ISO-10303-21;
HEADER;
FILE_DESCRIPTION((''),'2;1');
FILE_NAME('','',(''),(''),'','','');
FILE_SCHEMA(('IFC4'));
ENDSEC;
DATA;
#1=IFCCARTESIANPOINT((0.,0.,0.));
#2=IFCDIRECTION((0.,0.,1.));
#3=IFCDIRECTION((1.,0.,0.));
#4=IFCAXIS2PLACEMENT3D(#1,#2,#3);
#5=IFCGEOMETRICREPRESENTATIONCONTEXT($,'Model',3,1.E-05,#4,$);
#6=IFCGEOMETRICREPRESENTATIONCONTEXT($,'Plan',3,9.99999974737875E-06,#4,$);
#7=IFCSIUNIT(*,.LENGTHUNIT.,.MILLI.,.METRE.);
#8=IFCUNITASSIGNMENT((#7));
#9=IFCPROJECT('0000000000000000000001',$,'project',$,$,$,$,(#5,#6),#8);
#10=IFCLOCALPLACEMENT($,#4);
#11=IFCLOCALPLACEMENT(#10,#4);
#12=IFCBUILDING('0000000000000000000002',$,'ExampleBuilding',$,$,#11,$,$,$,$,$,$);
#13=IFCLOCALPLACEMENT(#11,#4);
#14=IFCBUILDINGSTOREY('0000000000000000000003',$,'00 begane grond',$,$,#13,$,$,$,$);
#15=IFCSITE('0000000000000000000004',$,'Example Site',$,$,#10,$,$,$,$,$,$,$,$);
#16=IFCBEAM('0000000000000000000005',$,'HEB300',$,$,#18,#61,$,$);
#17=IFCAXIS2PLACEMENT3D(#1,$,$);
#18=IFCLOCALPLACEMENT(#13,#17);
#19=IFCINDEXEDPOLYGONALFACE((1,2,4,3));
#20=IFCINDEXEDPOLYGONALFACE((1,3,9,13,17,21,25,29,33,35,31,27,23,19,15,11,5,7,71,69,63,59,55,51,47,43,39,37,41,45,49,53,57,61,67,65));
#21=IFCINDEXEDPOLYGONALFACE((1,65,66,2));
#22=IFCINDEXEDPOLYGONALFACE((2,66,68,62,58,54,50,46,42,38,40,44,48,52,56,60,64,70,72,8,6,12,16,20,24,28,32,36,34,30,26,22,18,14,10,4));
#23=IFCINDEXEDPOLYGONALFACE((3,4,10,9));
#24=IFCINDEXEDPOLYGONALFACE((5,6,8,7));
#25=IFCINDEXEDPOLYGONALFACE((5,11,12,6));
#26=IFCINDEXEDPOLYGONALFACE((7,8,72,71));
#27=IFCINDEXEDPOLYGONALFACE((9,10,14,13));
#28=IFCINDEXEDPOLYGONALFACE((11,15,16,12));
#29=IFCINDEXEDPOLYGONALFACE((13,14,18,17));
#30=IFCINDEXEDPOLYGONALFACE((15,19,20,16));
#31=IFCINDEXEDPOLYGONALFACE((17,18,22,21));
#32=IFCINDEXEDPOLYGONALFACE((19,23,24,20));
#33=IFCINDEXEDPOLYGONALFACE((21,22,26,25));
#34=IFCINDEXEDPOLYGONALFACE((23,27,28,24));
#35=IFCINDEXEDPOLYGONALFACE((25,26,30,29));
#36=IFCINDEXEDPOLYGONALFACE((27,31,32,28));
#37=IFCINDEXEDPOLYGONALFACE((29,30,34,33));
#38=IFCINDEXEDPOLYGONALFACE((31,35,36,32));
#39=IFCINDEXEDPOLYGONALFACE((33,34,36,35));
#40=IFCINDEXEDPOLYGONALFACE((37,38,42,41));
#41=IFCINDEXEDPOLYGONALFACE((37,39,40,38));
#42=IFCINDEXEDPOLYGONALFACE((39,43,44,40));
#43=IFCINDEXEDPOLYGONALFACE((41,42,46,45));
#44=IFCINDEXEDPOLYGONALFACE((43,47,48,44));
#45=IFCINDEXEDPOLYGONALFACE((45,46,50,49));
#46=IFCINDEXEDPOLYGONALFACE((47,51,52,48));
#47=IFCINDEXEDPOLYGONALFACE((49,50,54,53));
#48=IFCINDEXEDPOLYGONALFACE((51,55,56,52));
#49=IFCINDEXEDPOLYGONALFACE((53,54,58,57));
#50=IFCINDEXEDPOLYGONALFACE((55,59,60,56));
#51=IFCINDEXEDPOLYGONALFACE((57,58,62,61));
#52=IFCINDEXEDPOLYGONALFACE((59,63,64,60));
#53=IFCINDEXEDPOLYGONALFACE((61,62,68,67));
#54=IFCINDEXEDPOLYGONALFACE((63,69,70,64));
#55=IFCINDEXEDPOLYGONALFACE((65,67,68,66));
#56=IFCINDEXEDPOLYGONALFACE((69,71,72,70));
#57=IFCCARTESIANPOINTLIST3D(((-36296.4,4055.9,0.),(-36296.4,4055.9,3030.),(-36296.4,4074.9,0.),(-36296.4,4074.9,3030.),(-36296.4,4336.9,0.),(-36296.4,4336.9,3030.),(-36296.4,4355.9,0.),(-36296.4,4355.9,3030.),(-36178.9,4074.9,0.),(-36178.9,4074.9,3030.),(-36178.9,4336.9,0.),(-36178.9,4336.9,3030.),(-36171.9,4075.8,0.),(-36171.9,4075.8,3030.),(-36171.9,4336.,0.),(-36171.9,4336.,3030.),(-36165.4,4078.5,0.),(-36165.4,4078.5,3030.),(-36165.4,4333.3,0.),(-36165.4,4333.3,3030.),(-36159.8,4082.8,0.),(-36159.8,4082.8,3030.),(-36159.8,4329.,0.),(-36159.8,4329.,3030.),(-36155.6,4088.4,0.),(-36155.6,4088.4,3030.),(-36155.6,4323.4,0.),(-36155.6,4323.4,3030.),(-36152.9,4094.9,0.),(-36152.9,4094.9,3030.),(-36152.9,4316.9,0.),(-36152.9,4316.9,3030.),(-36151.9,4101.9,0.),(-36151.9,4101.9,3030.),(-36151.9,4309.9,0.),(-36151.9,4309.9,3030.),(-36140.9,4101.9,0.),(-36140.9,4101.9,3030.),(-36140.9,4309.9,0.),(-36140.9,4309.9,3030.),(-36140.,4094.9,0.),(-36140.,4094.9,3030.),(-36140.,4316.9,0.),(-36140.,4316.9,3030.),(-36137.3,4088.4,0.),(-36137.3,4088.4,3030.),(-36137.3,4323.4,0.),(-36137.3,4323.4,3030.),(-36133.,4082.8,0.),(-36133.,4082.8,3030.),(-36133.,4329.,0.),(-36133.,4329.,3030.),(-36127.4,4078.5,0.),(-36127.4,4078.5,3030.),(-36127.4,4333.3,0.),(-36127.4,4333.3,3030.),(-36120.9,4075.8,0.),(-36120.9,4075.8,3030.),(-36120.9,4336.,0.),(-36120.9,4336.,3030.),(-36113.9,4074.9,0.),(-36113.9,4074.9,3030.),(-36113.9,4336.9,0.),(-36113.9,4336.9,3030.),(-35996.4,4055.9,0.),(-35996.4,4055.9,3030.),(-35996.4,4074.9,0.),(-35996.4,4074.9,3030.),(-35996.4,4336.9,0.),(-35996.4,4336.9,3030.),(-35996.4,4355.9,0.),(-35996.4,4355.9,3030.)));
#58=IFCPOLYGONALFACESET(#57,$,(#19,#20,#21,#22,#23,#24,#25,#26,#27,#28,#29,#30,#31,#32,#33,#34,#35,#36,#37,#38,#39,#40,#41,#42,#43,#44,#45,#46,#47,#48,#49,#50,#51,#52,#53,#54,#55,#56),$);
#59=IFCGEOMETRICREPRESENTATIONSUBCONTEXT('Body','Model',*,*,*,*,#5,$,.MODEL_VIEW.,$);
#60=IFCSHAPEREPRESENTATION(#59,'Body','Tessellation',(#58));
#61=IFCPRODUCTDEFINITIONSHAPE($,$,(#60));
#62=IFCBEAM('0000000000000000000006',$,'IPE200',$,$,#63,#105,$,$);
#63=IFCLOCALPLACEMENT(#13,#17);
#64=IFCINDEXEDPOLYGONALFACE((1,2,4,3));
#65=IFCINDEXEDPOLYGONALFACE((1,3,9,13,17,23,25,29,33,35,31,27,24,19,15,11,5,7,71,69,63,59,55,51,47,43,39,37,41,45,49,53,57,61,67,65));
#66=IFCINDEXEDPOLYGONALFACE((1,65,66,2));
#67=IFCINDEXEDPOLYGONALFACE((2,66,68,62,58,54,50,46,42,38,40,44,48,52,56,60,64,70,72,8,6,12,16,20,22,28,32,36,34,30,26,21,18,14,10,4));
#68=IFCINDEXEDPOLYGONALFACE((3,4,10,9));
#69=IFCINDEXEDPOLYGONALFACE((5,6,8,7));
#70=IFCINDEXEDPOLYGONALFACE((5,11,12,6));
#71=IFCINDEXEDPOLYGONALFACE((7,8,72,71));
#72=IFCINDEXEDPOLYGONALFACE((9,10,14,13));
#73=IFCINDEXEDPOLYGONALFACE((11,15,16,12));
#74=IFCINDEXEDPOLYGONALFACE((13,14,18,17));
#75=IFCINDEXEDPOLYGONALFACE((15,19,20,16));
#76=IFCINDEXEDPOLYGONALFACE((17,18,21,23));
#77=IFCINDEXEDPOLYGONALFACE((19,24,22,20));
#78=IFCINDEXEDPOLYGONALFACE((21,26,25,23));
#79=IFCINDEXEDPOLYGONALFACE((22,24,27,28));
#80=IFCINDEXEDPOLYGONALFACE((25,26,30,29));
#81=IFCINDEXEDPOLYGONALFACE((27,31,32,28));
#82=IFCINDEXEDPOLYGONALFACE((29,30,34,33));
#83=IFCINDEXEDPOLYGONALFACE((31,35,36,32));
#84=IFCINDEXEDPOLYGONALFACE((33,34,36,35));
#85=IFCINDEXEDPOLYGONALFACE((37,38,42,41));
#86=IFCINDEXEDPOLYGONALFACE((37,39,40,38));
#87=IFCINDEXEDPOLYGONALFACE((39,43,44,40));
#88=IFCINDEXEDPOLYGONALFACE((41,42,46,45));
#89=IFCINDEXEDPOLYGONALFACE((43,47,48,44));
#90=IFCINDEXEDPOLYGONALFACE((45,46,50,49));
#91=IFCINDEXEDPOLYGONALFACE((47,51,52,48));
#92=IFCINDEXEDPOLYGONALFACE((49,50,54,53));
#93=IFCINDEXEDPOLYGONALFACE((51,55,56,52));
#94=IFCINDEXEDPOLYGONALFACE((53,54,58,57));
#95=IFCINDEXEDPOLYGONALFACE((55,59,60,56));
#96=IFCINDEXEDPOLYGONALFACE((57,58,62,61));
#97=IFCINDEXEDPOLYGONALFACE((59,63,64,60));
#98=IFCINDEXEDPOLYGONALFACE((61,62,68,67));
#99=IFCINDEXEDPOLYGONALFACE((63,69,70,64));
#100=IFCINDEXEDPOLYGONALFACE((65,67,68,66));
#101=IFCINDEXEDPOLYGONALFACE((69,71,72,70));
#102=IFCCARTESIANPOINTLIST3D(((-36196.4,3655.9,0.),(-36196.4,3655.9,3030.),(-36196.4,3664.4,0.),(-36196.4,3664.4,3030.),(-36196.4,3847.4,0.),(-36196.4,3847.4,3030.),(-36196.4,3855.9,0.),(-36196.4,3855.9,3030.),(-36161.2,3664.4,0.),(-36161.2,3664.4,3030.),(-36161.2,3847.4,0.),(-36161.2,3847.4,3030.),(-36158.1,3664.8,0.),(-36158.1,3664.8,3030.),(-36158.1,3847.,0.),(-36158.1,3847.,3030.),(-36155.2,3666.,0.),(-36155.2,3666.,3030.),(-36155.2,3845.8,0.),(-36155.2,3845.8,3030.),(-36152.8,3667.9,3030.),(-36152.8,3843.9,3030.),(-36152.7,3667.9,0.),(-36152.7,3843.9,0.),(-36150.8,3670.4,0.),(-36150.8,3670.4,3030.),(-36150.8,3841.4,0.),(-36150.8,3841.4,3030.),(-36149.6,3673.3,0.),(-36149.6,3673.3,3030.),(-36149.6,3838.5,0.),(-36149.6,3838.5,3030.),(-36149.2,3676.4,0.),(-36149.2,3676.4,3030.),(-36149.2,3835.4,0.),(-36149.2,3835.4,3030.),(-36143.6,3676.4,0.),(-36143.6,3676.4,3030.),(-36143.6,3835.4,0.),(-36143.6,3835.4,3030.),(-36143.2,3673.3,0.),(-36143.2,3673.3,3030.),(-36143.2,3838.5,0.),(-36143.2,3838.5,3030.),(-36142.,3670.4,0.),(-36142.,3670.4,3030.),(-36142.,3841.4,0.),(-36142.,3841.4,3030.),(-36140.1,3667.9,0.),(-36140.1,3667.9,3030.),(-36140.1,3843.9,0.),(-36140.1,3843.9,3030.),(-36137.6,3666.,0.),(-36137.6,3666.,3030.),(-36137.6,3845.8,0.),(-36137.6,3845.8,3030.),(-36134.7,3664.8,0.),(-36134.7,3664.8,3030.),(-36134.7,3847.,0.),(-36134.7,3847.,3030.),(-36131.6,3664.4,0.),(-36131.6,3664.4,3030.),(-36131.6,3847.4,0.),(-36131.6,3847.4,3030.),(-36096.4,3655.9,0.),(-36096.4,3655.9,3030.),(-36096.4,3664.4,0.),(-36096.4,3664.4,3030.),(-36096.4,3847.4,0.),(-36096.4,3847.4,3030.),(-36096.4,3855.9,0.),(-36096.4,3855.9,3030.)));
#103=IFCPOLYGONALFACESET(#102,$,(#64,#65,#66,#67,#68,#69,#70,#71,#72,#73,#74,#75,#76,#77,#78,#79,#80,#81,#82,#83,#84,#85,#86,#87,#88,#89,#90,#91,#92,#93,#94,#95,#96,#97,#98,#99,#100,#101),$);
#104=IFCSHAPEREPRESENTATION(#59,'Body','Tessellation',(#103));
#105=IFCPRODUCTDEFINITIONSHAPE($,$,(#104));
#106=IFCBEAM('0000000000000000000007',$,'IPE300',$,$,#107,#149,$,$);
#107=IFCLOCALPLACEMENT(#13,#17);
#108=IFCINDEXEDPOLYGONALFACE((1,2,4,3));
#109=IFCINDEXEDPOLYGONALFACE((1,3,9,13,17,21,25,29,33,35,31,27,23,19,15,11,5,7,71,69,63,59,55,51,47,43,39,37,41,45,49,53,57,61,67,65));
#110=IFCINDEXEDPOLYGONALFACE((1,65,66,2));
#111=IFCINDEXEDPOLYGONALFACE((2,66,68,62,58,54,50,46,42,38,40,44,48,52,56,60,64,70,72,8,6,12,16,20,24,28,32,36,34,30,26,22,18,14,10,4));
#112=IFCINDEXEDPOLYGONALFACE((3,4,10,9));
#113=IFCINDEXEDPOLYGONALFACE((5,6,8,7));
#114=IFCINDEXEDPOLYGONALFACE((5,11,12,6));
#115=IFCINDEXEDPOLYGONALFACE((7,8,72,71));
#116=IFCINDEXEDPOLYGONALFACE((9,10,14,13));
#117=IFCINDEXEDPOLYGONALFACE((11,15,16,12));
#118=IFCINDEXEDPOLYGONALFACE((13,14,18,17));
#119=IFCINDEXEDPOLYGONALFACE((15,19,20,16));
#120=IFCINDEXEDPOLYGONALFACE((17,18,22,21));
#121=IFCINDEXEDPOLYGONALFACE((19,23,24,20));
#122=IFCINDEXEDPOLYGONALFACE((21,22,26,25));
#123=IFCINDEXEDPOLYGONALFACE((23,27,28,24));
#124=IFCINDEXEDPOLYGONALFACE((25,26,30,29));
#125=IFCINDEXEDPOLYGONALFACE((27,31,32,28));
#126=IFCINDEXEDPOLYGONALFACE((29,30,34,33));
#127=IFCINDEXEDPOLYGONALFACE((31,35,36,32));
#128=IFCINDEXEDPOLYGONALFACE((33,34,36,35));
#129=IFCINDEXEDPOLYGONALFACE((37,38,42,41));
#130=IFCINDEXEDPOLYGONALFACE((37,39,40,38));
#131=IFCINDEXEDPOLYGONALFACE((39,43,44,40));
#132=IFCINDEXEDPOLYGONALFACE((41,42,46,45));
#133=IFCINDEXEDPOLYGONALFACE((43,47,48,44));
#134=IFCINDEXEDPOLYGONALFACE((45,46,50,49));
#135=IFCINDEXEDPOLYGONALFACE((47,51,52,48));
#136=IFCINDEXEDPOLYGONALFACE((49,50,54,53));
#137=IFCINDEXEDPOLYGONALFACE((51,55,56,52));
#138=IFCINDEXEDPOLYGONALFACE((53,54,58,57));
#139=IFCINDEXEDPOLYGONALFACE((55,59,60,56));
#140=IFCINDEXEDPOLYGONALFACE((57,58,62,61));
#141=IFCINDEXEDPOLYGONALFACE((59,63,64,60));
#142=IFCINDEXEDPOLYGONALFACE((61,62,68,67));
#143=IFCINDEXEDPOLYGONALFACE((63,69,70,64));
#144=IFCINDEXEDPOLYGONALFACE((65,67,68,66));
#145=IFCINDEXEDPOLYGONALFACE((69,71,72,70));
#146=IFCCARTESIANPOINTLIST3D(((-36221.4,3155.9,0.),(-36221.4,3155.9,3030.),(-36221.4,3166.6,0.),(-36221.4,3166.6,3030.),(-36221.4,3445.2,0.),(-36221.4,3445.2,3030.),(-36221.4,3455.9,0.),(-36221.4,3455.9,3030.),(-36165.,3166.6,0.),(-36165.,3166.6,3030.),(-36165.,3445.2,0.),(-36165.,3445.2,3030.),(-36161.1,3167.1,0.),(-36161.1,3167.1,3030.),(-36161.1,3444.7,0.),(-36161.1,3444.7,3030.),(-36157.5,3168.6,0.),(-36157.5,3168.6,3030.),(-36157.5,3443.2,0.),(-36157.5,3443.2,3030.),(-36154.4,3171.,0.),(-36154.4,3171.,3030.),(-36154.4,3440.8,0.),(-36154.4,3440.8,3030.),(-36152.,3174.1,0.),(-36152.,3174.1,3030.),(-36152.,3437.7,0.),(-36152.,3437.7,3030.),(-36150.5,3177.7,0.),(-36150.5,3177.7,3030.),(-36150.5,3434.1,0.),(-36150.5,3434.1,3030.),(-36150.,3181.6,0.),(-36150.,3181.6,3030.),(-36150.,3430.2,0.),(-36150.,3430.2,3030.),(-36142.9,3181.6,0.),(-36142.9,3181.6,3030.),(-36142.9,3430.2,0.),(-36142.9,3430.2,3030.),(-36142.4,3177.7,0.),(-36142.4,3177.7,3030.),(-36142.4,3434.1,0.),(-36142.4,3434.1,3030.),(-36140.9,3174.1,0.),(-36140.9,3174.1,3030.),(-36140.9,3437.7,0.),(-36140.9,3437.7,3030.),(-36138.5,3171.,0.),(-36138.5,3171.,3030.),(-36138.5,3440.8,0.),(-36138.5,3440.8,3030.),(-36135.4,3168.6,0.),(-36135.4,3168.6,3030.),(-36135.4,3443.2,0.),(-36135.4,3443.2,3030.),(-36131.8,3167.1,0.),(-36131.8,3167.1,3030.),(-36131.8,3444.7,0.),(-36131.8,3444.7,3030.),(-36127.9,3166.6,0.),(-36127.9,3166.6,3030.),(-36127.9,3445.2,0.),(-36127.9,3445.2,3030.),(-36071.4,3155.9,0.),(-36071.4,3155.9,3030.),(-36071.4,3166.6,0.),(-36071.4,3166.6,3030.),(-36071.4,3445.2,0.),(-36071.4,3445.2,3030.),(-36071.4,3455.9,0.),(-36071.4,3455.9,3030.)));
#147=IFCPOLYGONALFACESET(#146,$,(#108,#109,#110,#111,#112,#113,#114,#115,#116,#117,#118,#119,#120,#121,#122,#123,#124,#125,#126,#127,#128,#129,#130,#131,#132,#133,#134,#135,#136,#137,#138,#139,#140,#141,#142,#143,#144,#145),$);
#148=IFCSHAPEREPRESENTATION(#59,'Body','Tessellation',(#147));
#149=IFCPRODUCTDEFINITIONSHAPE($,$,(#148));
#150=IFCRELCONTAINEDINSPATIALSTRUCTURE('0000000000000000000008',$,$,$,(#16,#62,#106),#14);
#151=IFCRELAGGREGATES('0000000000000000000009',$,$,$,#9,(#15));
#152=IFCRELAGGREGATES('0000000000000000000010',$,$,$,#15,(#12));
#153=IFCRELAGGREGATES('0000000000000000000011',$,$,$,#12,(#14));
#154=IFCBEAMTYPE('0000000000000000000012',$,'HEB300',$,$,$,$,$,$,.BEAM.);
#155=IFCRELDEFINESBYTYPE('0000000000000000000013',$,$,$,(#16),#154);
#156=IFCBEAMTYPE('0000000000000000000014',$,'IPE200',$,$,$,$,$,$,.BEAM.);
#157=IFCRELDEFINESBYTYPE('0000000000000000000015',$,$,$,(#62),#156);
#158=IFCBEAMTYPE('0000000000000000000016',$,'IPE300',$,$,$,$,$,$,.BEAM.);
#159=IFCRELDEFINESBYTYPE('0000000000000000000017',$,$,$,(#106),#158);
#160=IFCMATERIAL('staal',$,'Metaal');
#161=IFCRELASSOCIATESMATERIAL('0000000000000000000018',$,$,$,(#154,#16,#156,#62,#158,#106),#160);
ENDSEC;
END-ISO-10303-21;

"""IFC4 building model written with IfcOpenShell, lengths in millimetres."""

from ifc_helpers import new_model, si_unit, frame, origin_with_axes, place, context, subcontext, project, spatial, i_section, extrude, material, material_profile, profile_set, profile_usage, type_object, element, save


model = new_model("IFC4")

# Units and contexts
model_context = context("Model", 3, precision=1e-05, world=origin_with_axes())
plan_context = context("Plan", 3, precision=9.99999974737875e-06, world=origin_with_axes())
body_context = subcontext(model_context, "Body", "Model", "MODEL_VIEW")
ifc_project = project(units=[si_unit("LENGTHUNIT", "METRE", prefix="MILLI")], contexts=[model_context, plan_context])

# Site, building, storey
site_placement = place(None, frame((0.0, 0.0, 0.0), z_axis=(0.0, 0.0, 1.0), x_axis=(1.0, 0.0, 0.0)))
site = spatial("IfcSite", under=ifc_project, at=site_placement, Name="Example Site")
building_placement = place(site_placement, frame((0.0, 0.0, 0.0), z_axis=(0.0, 0.0, 1.0), x_axis=(1.0, 0.0, 0.0)))
building = spatial("IfcBuilding", under=site, at=building_placement, Name="ExampleBuilding")
storey_placement = place(building_placement, frame((0.0, 0.0, 0.0), z_axis=(0.0, 0.0, 1.0), x_axis=(1.0, 0.0, 0.0)))
storey = spatial("IfcBuildingStorey", under=building, at=storey_placement, Name="00 begane grond")

# Beams
ifc_material_1 = material(Name="staal", Category="Metaal")
ifc_material_profile_1 = material_profile(ifc_material_1, i_section(OverallWidth=300.0, OverallDepth=300.0, WebThickness=11.0, FlangeThickness=19.0, FilletRadius=27.0))
ifc_profile_set_1 = profile_set([ifc_material_profile_1], Name="staal")
ifc_profile_usage_1 = profile_usage(ifc_profile_set_1, cardinal=5)
beam_type_1 = type_object("IfcBeamType", Name="HEB300", PredefinedType="BEAM", material=ifc_profile_set_1)
beam_1_placement = place(storey_placement, frame((-36146.4, 4205.9, 0.0), z_axis=(-0.000001, 0.0, 1.0), x_axis=(1.0, 0.0, 0.000001)))
element("IfcBeam", 1, at=beam_1_placement, inside=storey, type_object=beam_type_1, material=ifc_profile_usage_1, Name="HEB300", context=body_context, shape_type="SweptSolid", body=[
    extrude(i_section(OverallWidth=300.0, OverallDepth=300.0, WebThickness=11.0, FlangeThickness=19.0, FilletRadius=27.0), origin_with_axes(), (0.0, 0.0, 1.0), 3030.0),
])
ifc_material_profile_2 = material_profile(ifc_material_1, i_section(OverallWidth=100.0, OverallDepth=200.0, WebThickness=5.6, FlangeThickness=8.5, FilletRadius=12.0))
ifc_profile_set_2 = profile_set([ifc_material_profile_2], Name="staal")
ifc_profile_usage_2 = profile_usage(ifc_profile_set_2, cardinal=5)
beam_type_2 = type_object("IfcBeamType", Name="IPE200", PredefinedType="BEAM", material=ifc_profile_set_2)
beam_2_placement = place(storey_placement, frame((-36146.4, 3755.9, 0.0), z_axis=(-0.000001, 0.0, 1.0), x_axis=(1.0, 0.0, 0.000001)))
element("IfcBeam", 2, at=beam_2_placement, inside=storey, type_object=beam_type_2, material=ifc_profile_usage_2, Name="IPE200", context=body_context, shape_type="SweptSolid", body=[
    extrude(i_section(OverallWidth=100.0, OverallDepth=200.0, WebThickness=5.6, FlangeThickness=8.5, FilletRadius=12.0), origin_with_axes(), (0.0, 0.0, 1.0), 3030.0),
])
ifc_material_profile_3 = material_profile(ifc_material_1, i_section(OverallWidth=150.0, OverallDepth=300.0, WebThickness=7.1, FlangeThickness=10.7, FilletRadius=15.0))
ifc_profile_set_3 = profile_set([ifc_material_profile_3], Name="staal")
ifc_profile_usage_3 = profile_usage(ifc_profile_set_3, cardinal=5)
beam_type_3 = type_object("IfcBeamType", Name="IPE300", PredefinedType="BEAM", material=ifc_profile_set_3)
beam_3_placement = place(storey_placement, frame((-36146.4, 3305.9, 0.0), z_axis=(-0.000001, 0.0, 1.0), x_axis=(1.0, 0.0, 0.000001)))
element("IfcBeam", 3, at=beam_3_placement, inside=storey, type_object=beam_type_3, material=ifc_profile_usage_3, Name="IPE300", context=body_context, shape_type="SweptSolid", body=[
    extrude(i_section(OverallWidth=150.0, OverallDepth=300.0, WebThickness=7.1, FlangeThickness=10.7, FilletRadius=15.0), origin_with_axes(), (0.0, 0.0, 1.0), 3030.0),
])

save(model, "model.ifc")
